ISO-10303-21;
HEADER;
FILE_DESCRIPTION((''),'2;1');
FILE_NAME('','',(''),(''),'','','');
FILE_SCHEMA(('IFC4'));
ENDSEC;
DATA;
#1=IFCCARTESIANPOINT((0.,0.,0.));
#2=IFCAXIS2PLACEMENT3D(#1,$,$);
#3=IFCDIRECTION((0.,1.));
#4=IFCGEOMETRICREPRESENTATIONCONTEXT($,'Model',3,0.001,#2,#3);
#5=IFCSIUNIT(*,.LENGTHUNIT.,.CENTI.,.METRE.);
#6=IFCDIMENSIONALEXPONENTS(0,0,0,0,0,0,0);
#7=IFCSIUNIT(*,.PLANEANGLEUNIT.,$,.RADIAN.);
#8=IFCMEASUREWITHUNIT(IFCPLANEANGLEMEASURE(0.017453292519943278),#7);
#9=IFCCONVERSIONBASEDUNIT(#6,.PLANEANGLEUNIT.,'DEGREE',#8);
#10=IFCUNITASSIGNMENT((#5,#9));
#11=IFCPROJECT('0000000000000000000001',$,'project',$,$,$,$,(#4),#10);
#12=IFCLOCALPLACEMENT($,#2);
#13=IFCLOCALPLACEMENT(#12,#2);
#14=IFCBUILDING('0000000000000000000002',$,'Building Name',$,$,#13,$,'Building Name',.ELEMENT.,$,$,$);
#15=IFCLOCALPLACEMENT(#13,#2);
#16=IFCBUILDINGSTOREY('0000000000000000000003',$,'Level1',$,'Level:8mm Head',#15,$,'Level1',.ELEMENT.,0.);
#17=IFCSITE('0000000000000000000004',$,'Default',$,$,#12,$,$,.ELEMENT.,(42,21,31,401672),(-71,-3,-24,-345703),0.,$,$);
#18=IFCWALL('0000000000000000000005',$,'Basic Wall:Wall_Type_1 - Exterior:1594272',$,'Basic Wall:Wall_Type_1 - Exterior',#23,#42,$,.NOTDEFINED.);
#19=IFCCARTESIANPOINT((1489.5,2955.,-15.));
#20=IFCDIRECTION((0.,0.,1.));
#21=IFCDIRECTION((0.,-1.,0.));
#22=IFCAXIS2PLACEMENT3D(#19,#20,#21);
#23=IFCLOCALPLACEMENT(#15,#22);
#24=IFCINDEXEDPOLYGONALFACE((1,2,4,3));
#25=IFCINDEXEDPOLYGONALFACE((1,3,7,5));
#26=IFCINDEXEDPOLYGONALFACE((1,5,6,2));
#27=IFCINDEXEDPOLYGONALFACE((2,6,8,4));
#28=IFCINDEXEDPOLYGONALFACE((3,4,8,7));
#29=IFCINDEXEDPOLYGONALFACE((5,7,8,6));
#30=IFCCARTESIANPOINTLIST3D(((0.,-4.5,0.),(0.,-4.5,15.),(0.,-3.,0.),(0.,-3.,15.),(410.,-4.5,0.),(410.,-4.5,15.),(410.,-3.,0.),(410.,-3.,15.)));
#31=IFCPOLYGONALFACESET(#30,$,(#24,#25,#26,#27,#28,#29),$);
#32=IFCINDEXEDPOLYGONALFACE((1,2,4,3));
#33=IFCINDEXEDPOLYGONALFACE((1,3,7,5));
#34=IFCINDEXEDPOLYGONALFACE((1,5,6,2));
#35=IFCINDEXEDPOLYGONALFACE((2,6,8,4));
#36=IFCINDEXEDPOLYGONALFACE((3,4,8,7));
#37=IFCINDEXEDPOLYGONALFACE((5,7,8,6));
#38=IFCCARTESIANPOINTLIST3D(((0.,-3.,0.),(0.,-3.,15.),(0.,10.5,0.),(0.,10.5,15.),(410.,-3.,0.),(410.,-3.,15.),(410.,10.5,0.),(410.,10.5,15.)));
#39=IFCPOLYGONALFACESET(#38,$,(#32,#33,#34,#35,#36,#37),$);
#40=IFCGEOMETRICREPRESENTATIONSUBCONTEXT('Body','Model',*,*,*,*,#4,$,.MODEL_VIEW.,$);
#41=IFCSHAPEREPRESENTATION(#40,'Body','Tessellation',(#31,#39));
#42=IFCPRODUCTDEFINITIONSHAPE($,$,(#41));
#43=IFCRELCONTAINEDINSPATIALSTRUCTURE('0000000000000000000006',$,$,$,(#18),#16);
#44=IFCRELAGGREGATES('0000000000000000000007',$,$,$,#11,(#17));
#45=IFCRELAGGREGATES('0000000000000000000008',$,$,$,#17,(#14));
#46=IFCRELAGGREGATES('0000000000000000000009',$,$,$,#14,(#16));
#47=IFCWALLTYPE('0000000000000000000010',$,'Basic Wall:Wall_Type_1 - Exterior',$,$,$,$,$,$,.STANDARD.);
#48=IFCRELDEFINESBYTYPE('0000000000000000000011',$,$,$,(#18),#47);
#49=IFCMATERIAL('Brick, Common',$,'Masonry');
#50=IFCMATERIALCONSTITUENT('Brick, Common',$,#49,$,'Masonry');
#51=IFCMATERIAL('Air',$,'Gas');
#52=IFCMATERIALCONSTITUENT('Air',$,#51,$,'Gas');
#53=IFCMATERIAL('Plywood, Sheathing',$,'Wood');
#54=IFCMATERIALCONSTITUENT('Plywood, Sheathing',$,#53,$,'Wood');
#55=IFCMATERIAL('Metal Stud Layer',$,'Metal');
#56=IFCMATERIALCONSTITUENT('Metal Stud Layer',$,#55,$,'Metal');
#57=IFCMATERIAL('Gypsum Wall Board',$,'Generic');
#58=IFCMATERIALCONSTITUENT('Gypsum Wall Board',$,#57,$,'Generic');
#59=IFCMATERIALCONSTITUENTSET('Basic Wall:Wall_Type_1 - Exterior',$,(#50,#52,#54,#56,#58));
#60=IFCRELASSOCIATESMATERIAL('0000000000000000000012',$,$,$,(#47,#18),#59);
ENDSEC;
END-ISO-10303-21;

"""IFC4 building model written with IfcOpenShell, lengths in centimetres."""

from ifc_helpers import new_model, entity, si_unit, converted_unit, direction, frame, origin, place, context, subcontext, project, spatial, indexed_curve, outline, extrude, material, constituent, constituent_set, type_object, element, save


model = new_model("IFC4")

# Units and contexts
model_context = context("Model", 3, precision=0.001, world=origin(), true_north=direction((0.0, 1.0)))
body_context = subcontext(model_context, "Body", "Model", "MODEL_VIEW")
ifc_project = project(units=[si_unit("LENGTHUNIT", "METRE", prefix="CENTI"), converted_unit("PLANEANGLEUNIT", "DEGREE", entity("IfcPlaneAngleMeasure", 0.017453292519943278), si_unit("PLANEANGLEUNIT", "RADIAN"), dimensions=[0, 0, 0, 0, 0, 0, 0])], contexts=[model_context])

# Site, building, storey
site_placement = place(None, origin())
site = spatial("IfcSite", under=ifc_project, at=site_placement, Name="Default", CompositionType="ELEMENT", RefLatitude=(42, 21, 31, 401672), RefLongitude=(-71, -3, -24, -345703), RefElevation=0.0)
building_placement = place(site_placement, origin())
building = spatial("IfcBuilding", under=site, at=building_placement, Name="Building Name", LongName="Building Name", CompositionType="ELEMENT")
storey_placement = place(building_placement, origin())
storey = spatial("IfcBuildingStorey", under=building, at=storey_placement, Name="Level1", ObjectType="Level:8mm Head", LongName="Level1", CompositionType="ELEMENT", Elevation=0.0)

# Wall, opening
ifc_material_1 = material(Name="Brick, Common", Category="Masonry")
ifc_constituent_1 = constituent(ifc_material_1, Name="Brick, Common", Category="Masonry")
ifc_material_2 = material(Name="Air", Category="Gas")
ifc_constituent_2 = constituent(ifc_material_2, Name="Air", Category="Gas")
ifc_material_3 = material(Name="Plywood, Sheathing", Category="Wood")
ifc_constituent_3 = constituent(ifc_material_3, Name="Plywood, Sheathing", Category="Wood")
ifc_material_4 = material(Name="Metal Stud Layer", Category="Metal")
ifc_constituent_4 = constituent(ifc_material_4, Name="Metal Stud Layer", Category="Metal")
ifc_material_5 = material(Name="Gypsum Wall Board", Category="Generic")
ifc_constituent_5 = constituent(ifc_material_5, Name="Gypsum Wall Board", Category="Generic")
ifc_constituent_set_1 = constituent_set(constituents=[ifc_constituent_1, ifc_constituent_2, ifc_constituent_3, ifc_constituent_4, ifc_constituent_5], Name="Basic Wall:Wall_Type_1 - Exterior")
wall_type_1 = type_object("IfcWallType", Name="Basic Wall:Wall_Type_1 - Exterior", PredefinedType="STANDARD", material=ifc_constituent_set_1)
wall_1_placement = place(storey_placement, frame((1489.5, 2955.0, -15.0), z_axis=(0.0, 0.0, 1.0), x_axis=(0.0, -1.0, 0.0)))
wall_1 = element("IfcWall", 1, at=wall_1_placement, inside=storey, type_object=wall_type_1, material=ifc_constituent_set_1, Name="Basic Wall:Wall_Type_1 - Exterior:1594272", ObjectType="Basic Wall:Wall_Type_1 - Exterior", PredefinedType="NOTDEFINED", context=body_context, shape_type="SweptSolid", body=[
    extrude(outline(indexed_curve([(-205.0, -0.75), (205.0, -0.75), (205.0, 0.75), (-205.0, 0.75), (-205.0, -0.75)], self_intersect=False)), frame((205.0, -3.75, 0.0)), (0.0, 0.0, 1.0), 15.0),
    extrude(outline(indexed_curve([(-6.75, -205.0), (6.75, -205.0), (6.75, 205.0), (-6.75, 205.0), (-6.75, -205.0)], self_intersect=False)), frame((205.0, 3.75, 0.0), z_axis=(0.0, 0.0, 1.0), x_axis=(0.0, -1.0, 0.0)), (0.0, 0.0, 1.0), 15.0),
])
opening_placement = place(wall_1_placement, origin())
element("IfcOpeningElement", 2, at=opening_placement, cuts=wall_1, PredefinedType="OPENING", context=body_context, shape_type="SweptSolid", body=[
    extrude(outline(indexed_curve([(-215.0, -205.0), (215.0, -205.0), (215.0, 205.0), (-215.0, 205.0), (-215.0, -205.0)], self_intersect=False)), frame((205.0, -25.74, 230.0), z_axis=(0.0, 1.0, 0.0), x_axis=(0.0, 0.0, 1.0)), (0.0, 0.0, 1.0), 51.48),
])

save(model, "model.ifc")
